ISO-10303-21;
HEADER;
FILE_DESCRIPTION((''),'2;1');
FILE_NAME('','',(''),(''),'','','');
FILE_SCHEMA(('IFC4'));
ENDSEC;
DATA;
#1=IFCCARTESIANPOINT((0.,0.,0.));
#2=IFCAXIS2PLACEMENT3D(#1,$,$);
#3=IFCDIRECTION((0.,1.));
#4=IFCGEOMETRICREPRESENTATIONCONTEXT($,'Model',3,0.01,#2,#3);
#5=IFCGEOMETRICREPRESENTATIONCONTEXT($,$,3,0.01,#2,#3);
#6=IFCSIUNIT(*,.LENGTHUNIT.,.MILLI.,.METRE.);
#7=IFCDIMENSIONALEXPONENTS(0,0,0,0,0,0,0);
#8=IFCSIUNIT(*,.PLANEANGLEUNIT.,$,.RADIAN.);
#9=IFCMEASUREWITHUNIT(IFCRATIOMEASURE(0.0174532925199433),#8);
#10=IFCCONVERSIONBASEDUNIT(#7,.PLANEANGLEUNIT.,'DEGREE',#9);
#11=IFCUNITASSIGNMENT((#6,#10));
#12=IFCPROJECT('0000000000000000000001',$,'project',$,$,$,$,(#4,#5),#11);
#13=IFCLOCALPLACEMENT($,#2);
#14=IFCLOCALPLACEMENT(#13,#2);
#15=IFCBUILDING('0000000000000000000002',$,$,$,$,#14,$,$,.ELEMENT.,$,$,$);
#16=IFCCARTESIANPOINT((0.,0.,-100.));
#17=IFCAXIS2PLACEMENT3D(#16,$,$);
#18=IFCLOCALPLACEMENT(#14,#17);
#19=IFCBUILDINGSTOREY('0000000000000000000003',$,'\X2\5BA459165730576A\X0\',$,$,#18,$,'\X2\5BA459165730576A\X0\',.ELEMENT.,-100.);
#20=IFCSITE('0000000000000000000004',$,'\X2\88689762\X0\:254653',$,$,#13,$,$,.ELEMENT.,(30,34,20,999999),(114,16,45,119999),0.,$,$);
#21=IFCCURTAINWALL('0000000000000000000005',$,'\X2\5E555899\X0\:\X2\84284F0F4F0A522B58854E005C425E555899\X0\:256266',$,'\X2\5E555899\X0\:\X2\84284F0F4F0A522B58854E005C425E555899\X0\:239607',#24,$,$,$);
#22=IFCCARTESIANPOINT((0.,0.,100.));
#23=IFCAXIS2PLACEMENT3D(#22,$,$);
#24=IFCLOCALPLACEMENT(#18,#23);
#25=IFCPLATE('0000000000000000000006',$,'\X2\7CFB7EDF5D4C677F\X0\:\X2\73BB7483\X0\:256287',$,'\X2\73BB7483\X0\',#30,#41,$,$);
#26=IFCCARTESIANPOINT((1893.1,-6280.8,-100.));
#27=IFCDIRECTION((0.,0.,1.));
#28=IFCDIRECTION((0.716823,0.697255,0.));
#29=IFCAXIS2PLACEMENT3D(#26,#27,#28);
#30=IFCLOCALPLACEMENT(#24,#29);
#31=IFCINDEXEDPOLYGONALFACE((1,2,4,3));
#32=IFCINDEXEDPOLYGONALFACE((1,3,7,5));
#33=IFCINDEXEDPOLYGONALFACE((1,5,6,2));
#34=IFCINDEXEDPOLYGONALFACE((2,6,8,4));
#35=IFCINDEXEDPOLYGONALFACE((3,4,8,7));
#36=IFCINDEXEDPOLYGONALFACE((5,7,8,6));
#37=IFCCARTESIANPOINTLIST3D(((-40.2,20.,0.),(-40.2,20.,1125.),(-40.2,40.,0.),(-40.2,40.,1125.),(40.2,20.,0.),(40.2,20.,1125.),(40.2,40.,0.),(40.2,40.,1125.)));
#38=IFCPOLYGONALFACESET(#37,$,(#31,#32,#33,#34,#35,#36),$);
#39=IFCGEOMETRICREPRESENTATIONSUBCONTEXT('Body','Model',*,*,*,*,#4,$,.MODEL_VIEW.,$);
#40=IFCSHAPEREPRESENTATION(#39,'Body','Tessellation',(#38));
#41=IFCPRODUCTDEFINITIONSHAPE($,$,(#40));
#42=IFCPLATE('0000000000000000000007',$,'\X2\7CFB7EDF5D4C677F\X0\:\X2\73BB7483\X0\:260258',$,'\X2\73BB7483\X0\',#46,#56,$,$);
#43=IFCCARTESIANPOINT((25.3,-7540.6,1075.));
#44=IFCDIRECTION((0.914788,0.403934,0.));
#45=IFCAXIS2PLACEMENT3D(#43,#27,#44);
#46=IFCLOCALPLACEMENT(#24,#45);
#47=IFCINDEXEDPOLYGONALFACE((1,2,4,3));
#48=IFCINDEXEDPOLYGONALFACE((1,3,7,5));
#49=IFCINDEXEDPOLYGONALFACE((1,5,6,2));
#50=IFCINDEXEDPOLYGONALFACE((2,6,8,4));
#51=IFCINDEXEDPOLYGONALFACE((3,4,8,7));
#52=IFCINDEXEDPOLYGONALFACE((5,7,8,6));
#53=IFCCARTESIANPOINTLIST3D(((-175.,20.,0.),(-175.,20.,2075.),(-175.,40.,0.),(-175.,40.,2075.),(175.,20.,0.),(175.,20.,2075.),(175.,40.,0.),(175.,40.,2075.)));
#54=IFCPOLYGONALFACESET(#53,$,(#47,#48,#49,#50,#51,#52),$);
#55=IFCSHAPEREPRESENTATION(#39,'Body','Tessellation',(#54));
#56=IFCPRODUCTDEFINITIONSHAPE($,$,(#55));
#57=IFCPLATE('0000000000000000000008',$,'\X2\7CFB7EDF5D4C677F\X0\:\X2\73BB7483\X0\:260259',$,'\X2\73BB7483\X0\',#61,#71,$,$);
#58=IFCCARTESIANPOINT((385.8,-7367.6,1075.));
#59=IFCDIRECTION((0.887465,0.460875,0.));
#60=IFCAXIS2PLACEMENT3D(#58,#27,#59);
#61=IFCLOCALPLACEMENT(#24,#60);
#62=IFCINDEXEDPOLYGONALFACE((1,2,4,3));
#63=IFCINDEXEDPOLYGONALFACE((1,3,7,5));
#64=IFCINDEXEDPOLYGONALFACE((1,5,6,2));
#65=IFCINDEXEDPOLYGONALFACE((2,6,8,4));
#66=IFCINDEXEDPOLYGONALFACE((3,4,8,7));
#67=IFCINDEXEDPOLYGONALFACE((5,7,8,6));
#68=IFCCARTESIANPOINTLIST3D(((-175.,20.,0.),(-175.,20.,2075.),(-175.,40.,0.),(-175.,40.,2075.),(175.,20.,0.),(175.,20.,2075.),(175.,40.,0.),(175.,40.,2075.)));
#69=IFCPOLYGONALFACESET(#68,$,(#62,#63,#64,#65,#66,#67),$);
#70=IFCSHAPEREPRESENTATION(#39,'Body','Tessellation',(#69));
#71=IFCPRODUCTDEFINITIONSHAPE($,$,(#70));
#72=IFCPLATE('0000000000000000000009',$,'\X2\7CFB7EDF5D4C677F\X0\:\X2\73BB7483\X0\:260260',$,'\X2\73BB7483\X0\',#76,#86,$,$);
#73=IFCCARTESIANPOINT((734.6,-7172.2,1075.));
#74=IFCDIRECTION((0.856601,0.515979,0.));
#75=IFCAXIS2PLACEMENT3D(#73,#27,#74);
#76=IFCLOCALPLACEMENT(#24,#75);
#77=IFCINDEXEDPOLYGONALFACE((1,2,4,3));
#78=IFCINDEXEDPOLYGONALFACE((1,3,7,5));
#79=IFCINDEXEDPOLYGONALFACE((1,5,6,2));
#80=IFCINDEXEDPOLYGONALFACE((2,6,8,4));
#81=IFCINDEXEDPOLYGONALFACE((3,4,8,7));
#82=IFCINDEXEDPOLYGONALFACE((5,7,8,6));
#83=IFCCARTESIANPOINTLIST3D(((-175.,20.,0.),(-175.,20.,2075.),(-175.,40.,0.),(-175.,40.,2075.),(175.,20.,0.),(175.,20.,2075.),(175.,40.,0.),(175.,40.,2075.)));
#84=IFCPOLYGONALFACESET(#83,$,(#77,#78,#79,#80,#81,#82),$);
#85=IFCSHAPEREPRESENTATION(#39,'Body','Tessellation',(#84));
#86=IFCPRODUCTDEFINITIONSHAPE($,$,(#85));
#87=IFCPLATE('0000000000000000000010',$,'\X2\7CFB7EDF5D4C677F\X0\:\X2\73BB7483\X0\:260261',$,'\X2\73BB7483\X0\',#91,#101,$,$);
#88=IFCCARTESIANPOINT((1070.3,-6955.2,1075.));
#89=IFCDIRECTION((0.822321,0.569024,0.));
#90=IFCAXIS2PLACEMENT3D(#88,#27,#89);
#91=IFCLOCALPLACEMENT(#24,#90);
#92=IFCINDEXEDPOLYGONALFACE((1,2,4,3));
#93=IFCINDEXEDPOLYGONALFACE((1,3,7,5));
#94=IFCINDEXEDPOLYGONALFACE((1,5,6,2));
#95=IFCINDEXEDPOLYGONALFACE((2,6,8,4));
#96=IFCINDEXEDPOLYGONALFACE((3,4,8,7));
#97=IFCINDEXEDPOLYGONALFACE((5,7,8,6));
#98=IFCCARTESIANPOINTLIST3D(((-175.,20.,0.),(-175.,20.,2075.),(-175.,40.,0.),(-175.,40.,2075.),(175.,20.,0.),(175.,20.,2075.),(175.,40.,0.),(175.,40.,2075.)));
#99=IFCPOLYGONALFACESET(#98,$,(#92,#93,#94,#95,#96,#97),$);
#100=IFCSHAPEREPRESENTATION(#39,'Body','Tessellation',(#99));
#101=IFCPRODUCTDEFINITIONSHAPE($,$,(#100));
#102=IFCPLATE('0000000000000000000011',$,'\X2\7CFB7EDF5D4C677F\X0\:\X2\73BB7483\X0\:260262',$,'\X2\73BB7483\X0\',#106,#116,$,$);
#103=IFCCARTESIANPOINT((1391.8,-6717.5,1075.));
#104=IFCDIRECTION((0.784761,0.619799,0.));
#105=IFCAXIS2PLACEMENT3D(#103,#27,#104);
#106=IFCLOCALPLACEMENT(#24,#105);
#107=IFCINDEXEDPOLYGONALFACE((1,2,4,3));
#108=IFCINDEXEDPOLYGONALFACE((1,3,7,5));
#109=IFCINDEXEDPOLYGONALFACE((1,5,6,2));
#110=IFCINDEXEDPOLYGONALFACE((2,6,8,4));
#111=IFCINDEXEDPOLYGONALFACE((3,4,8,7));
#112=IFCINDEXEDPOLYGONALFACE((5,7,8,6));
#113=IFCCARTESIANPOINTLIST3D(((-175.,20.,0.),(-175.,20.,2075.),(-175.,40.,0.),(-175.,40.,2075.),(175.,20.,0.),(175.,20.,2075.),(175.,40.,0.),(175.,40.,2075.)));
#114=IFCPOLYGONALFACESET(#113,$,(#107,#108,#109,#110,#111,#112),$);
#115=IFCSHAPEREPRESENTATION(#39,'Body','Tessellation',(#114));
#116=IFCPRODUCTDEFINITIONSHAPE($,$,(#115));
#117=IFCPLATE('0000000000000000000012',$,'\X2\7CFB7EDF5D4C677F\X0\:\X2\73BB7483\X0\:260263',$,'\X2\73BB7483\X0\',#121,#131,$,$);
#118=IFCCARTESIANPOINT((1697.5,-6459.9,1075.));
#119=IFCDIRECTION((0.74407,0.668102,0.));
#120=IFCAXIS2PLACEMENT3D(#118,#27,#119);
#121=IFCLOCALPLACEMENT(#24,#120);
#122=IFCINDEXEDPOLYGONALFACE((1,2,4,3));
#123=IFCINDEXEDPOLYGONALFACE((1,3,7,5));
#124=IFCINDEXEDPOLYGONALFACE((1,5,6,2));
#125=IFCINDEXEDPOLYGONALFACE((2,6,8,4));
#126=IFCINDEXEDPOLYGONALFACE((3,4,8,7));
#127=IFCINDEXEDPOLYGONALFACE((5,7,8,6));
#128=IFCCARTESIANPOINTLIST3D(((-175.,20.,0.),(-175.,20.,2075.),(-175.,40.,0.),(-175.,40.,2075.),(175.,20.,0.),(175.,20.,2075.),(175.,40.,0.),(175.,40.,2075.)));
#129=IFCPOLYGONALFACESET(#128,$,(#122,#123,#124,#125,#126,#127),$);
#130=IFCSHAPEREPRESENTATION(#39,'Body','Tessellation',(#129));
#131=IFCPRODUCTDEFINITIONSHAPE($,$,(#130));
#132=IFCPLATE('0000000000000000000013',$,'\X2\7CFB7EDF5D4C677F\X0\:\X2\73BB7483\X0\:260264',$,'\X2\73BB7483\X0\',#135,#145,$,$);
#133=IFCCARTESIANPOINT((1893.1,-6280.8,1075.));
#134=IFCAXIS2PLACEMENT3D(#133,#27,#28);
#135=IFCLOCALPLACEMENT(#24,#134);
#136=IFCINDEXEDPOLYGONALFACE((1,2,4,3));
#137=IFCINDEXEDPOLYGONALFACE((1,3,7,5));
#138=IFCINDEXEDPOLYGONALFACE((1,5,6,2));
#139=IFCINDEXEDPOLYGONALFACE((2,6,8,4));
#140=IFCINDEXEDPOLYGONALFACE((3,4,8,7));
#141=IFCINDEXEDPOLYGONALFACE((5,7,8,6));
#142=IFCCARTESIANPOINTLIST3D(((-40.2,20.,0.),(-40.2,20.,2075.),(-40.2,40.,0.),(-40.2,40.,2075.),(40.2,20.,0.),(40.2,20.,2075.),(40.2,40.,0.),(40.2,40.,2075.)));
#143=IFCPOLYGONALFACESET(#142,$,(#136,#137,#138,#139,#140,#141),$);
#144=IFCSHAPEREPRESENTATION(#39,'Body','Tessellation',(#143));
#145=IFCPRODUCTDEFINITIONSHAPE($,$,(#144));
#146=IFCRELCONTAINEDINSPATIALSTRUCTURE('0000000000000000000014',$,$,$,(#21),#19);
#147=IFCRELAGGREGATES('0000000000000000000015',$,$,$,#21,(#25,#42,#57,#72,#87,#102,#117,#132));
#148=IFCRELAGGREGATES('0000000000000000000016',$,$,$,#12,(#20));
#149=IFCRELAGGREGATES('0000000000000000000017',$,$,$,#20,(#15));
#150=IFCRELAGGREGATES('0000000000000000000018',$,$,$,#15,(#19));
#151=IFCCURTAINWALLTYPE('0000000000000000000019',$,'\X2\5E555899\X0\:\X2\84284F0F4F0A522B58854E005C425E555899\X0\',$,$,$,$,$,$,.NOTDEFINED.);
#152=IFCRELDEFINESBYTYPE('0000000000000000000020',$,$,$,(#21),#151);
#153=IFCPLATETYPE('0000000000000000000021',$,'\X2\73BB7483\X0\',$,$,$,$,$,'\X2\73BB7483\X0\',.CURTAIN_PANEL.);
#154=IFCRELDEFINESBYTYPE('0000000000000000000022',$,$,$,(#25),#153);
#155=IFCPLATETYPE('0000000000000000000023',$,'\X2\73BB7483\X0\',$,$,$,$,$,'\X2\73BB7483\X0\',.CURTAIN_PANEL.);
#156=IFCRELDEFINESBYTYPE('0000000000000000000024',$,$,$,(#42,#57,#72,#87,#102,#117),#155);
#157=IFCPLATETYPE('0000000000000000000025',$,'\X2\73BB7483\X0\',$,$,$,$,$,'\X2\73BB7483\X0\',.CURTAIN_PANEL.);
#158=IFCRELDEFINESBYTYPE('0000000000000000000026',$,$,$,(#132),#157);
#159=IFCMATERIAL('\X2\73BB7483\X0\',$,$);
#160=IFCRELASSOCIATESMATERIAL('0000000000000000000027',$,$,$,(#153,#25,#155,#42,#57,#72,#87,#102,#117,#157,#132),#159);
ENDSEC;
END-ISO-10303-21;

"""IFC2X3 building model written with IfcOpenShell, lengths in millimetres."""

from ifc_helpers import new_model, entity, si_unit, converted_unit, direction, frame, frame_2d, origin, place, context, subcontext, project, spatial, rectangle, extrude, source, transform, mapped, material, type_object, type_shapes, element, aggregate, save


model = new_model("IFC2X3")

# Units and contexts
model_context = context("Model", 3, precision=0.01, world=origin(), true_north=direction((0.0, 1.0)))
context_of_model = context(None, 3, precision=0.01, world=origin(), true_north=direction((0.0, 1.0)))
body_context = subcontext(model_context, "Body", "Model", "MODEL_VIEW")
ifc_project = project(units=[si_unit("LENGTHUNIT", "METRE", prefix="MILLI"), converted_unit("PLANEANGLEUNIT", "DEGREE", entity("IfcRatioMeasure", 0.0174532925199433), si_unit("PLANEANGLEUNIT", "RADIAN"), dimensions=[0, 0, 0, 0, 0, 0, 0])], contexts=[model_context, context_of_model])

# Site, building, storey
site_placement = place(None, origin())
site = spatial("IfcSite", under=ifc_project, at=site_placement, Name="表面:254653", CompositionType="ELEMENT", RefLatitude=(30, 34, 20, 999999), RefLongitude=(114, 16, 45, 119999), RefElevation=0.0)
building_placement = place(site_placement, origin())
building = spatial("IfcBuilding", under=site, at=building_placement, CompositionType="ELEMENT")
storey_placement = place(building_placement, frame((0.0, 0.0, -100.0)))
storey = spatial("IfcBuildingStorey", under=building, at=storey_placement, Name="室外地坪", LongName="室外地坪", CompositionType="ELEMENT", Elevation=-100.0)

# Curtain wall, plates
curtain_wall_type = type_object("IfcCurtainWallType", Name="幕墙:萨伏伊别墅一层幕墙", PredefinedType="NOTDEFINED")
curtain_wall_placement = place(storey_placement, frame((0.0, 0.0, 100.0)))
curtain_wall = element("IfcCurtainWall", 1, at=curtain_wall_placement, inside=storey, type_object=curtain_wall_type, Name="幕墙:萨伏伊别墅一层幕墙:256266", ObjectType="幕墙:萨伏伊别墅一层幕墙:239607")
ifc_material_1 = material(Name="玻璃")
plate_type_1 = type_object("IfcPlateType", Name="玻璃", ElementType="玻璃", PredefinedType="CURTAIN_PANEL", material=ifc_material_1)
shared_shape_1 = source(origin(), body_context, "Body", "SweptSolid", [
    extrude(rectangle(XDim=20.0, YDim=80.4, at=frame_2d((0.0, 0.0), x_axis=(1.0, 0.0))), frame((0.0, 30.0, 0.0), z_axis=(0.0, 0.0, 1.0), x_axis=(0.0, 1.0, 0.0)), (0.0, 0.0, 1.0), 1125.0),
])
type_shapes(plate_type_1, [shared_shape_1])
plate_1_placement = place(curtain_wall_placement, frame((1893.1, -6280.8, -100.0), z_axis=(0.0, 0.0, 1.0), x_axis=(0.716823, 0.697255, 0.0)))
plate_1 = element("IfcPlate", 2, at=plate_1_placement, type_object=plate_type_1, material=ifc_material_1, Name="系统嵌板:玻璃:256287", ObjectType="玻璃", context=body_context, shape_type="MappedRepresentation", body=[
    mapped(shared_shape_1, transform((0.0, 0.0, 0.0), scale=1.0)),
])
plate_type_2 = type_object("IfcPlateType", Name="玻璃", ElementType="玻璃", PredefinedType="CURTAIN_PANEL", material=ifc_material_1)
shared_shape_2 = source(origin(), body_context, "Body", "SweptSolid", [
    extrude(rectangle(XDim=20.0, YDim=350.0, at=frame_2d((0.0, 0.0), x_axis=(1.0, 0.0))), frame((0.0, 30.0, 0.0), z_axis=(0.0, 0.0, 1.0), x_axis=(0.0, 1.0, 0.0)), (0.0, 0.0, 1.0), 2075.0),
])
type_shapes(plate_type_2, [shared_shape_2])
plate_2_placement = place(curtain_wall_placement, frame((25.3, -7540.6, 1075.0), z_axis=(0.0, 0.0, 1.0), x_axis=(0.914788, 0.403934, 0.0)))
plate_2 = element("IfcPlate", 3, at=plate_2_placement, type_object=plate_type_2, material=ifc_material_1, Name="系统嵌板:玻璃:260258", ObjectType="玻璃", context=body_context, shape_type="MappedRepresentation", body=[
    mapped(shared_shape_2, transform((0.0, 0.0, 0.0), scale=1.0)),
])
plate_3_placement = place(curtain_wall_placement, frame((385.8, -7367.6, 1075.0), z_axis=(0.0, 0.0, 1.0), x_axis=(0.887465, 0.460875, 0.0)))
plate_3 = element("IfcPlate", 4, at=plate_3_placement, type_object=plate_type_2, material=ifc_material_1, Name="系统嵌板:玻璃:260259", ObjectType="玻璃", context=body_context, shape_type="MappedRepresentation", body=[
    mapped(shared_shape_2, transform((0.0, 0.0, 0.0), scale=1.0)),
])
plate_4_placement = place(curtain_wall_placement, frame((734.6, -7172.2, 1075.0), z_axis=(0.0, 0.0, 1.0), x_axis=(0.856601, 0.515979, 0.0)))
plate_4 = element("IfcPlate", 5, at=plate_4_placement, type_object=plate_type_2, material=ifc_material_1, Name="系统嵌板:玻璃:260260", ObjectType="玻璃", context=body_context, shape_type="MappedRepresentation", body=[
    mapped(shared_shape_2, transform((0.0, 0.0, 0.0), scale=1.0)),
])
plate_5_placement = place(curtain_wall_placement, frame((1070.3, -6955.2, 1075.0), z_axis=(0.0, 0.0, 1.0), x_axis=(0.822321, 0.569024, 0.0)))
plate_5 = element("IfcPlate", 6, at=plate_5_placement, type_object=plate_type_2, material=ifc_material_1, Name="系统嵌板:玻璃:260261", ObjectType="玻璃", context=body_context, shape_type="MappedRepresentation", body=[
    mapped(shared_shape_2, transform((0.0, 0.0, 0.0), scale=1.0)),
])
plate_6_placement = place(curtain_wall_placement, frame((1391.8, -6717.5, 1075.0), z_axis=(0.0, 0.0, 1.0), x_axis=(0.784761, 0.619799, 0.0)))
plate_6 = element("IfcPlate", 7, at=plate_6_placement, type_object=plate_type_2, material=ifc_material_1, Name="系统嵌板:玻璃:260262", ObjectType="玻璃", context=body_context, shape_type="MappedRepresentation", body=[
    mapped(shared_shape_2, transform((0.0, 0.0, 0.0), scale=1.0)),
])
plate_7_placement = place(curtain_wall_placement, frame((1697.5, -6459.9, 1075.0), z_axis=(0.0, 0.0, 1.0), x_axis=(0.74407, 0.668102, 0.0)))
plate_7 = element("IfcPlate", 8, at=plate_7_placement, type_object=plate_type_2, material=ifc_material_1, Name="系统嵌板:玻璃:260263", ObjectType="玻璃", context=body_context, shape_type="MappedRepresentation", body=[
    mapped(shared_shape_2, transform((0.0, 0.0, 0.0), scale=1.0)),
])
plate_type_3 = type_object("IfcPlateType", Name="玻璃", ElementType="玻璃", PredefinedType="CURTAIN_PANEL", material=ifc_material_1)
shared_shape_3 = source(origin(), body_context, "Body", "SweptSolid", [
    extrude(rectangle(XDim=20.0, YDim=80.4, at=frame_2d((0.0, 0.0), x_axis=(1.0, 0.0))), frame((0.0, 30.0, 0.0), z_axis=(0.0, 0.0, 1.0), x_axis=(0.0, 1.0, 0.0)), (0.0, 0.0, 1.0), 2075.0),
])
type_shapes(plate_type_3, [shared_shape_3])
plate_8_placement = place(curtain_wall_placement, frame((1893.1, -6280.8, 1075.0), z_axis=(0.0, 0.0, 1.0), x_axis=(0.716823, 0.697255, 0.0)))
plate_8 = element("IfcPlate", 9, at=plate_8_placement, type_object=plate_type_3, material=ifc_material_1, Name="系统嵌板:玻璃:260264", ObjectType="玻璃", context=body_context, shape_type="MappedRepresentation", body=[
    mapped(shared_shape_3, transform((0.0, 0.0, 0.0), scale=1.0)),
])
aggregate(curtain_wall, [plate_1, plate_2, plate_3, plate_4, plate_5, plate_6, plate_7, plate_8])

save(model, "model.ifc")
